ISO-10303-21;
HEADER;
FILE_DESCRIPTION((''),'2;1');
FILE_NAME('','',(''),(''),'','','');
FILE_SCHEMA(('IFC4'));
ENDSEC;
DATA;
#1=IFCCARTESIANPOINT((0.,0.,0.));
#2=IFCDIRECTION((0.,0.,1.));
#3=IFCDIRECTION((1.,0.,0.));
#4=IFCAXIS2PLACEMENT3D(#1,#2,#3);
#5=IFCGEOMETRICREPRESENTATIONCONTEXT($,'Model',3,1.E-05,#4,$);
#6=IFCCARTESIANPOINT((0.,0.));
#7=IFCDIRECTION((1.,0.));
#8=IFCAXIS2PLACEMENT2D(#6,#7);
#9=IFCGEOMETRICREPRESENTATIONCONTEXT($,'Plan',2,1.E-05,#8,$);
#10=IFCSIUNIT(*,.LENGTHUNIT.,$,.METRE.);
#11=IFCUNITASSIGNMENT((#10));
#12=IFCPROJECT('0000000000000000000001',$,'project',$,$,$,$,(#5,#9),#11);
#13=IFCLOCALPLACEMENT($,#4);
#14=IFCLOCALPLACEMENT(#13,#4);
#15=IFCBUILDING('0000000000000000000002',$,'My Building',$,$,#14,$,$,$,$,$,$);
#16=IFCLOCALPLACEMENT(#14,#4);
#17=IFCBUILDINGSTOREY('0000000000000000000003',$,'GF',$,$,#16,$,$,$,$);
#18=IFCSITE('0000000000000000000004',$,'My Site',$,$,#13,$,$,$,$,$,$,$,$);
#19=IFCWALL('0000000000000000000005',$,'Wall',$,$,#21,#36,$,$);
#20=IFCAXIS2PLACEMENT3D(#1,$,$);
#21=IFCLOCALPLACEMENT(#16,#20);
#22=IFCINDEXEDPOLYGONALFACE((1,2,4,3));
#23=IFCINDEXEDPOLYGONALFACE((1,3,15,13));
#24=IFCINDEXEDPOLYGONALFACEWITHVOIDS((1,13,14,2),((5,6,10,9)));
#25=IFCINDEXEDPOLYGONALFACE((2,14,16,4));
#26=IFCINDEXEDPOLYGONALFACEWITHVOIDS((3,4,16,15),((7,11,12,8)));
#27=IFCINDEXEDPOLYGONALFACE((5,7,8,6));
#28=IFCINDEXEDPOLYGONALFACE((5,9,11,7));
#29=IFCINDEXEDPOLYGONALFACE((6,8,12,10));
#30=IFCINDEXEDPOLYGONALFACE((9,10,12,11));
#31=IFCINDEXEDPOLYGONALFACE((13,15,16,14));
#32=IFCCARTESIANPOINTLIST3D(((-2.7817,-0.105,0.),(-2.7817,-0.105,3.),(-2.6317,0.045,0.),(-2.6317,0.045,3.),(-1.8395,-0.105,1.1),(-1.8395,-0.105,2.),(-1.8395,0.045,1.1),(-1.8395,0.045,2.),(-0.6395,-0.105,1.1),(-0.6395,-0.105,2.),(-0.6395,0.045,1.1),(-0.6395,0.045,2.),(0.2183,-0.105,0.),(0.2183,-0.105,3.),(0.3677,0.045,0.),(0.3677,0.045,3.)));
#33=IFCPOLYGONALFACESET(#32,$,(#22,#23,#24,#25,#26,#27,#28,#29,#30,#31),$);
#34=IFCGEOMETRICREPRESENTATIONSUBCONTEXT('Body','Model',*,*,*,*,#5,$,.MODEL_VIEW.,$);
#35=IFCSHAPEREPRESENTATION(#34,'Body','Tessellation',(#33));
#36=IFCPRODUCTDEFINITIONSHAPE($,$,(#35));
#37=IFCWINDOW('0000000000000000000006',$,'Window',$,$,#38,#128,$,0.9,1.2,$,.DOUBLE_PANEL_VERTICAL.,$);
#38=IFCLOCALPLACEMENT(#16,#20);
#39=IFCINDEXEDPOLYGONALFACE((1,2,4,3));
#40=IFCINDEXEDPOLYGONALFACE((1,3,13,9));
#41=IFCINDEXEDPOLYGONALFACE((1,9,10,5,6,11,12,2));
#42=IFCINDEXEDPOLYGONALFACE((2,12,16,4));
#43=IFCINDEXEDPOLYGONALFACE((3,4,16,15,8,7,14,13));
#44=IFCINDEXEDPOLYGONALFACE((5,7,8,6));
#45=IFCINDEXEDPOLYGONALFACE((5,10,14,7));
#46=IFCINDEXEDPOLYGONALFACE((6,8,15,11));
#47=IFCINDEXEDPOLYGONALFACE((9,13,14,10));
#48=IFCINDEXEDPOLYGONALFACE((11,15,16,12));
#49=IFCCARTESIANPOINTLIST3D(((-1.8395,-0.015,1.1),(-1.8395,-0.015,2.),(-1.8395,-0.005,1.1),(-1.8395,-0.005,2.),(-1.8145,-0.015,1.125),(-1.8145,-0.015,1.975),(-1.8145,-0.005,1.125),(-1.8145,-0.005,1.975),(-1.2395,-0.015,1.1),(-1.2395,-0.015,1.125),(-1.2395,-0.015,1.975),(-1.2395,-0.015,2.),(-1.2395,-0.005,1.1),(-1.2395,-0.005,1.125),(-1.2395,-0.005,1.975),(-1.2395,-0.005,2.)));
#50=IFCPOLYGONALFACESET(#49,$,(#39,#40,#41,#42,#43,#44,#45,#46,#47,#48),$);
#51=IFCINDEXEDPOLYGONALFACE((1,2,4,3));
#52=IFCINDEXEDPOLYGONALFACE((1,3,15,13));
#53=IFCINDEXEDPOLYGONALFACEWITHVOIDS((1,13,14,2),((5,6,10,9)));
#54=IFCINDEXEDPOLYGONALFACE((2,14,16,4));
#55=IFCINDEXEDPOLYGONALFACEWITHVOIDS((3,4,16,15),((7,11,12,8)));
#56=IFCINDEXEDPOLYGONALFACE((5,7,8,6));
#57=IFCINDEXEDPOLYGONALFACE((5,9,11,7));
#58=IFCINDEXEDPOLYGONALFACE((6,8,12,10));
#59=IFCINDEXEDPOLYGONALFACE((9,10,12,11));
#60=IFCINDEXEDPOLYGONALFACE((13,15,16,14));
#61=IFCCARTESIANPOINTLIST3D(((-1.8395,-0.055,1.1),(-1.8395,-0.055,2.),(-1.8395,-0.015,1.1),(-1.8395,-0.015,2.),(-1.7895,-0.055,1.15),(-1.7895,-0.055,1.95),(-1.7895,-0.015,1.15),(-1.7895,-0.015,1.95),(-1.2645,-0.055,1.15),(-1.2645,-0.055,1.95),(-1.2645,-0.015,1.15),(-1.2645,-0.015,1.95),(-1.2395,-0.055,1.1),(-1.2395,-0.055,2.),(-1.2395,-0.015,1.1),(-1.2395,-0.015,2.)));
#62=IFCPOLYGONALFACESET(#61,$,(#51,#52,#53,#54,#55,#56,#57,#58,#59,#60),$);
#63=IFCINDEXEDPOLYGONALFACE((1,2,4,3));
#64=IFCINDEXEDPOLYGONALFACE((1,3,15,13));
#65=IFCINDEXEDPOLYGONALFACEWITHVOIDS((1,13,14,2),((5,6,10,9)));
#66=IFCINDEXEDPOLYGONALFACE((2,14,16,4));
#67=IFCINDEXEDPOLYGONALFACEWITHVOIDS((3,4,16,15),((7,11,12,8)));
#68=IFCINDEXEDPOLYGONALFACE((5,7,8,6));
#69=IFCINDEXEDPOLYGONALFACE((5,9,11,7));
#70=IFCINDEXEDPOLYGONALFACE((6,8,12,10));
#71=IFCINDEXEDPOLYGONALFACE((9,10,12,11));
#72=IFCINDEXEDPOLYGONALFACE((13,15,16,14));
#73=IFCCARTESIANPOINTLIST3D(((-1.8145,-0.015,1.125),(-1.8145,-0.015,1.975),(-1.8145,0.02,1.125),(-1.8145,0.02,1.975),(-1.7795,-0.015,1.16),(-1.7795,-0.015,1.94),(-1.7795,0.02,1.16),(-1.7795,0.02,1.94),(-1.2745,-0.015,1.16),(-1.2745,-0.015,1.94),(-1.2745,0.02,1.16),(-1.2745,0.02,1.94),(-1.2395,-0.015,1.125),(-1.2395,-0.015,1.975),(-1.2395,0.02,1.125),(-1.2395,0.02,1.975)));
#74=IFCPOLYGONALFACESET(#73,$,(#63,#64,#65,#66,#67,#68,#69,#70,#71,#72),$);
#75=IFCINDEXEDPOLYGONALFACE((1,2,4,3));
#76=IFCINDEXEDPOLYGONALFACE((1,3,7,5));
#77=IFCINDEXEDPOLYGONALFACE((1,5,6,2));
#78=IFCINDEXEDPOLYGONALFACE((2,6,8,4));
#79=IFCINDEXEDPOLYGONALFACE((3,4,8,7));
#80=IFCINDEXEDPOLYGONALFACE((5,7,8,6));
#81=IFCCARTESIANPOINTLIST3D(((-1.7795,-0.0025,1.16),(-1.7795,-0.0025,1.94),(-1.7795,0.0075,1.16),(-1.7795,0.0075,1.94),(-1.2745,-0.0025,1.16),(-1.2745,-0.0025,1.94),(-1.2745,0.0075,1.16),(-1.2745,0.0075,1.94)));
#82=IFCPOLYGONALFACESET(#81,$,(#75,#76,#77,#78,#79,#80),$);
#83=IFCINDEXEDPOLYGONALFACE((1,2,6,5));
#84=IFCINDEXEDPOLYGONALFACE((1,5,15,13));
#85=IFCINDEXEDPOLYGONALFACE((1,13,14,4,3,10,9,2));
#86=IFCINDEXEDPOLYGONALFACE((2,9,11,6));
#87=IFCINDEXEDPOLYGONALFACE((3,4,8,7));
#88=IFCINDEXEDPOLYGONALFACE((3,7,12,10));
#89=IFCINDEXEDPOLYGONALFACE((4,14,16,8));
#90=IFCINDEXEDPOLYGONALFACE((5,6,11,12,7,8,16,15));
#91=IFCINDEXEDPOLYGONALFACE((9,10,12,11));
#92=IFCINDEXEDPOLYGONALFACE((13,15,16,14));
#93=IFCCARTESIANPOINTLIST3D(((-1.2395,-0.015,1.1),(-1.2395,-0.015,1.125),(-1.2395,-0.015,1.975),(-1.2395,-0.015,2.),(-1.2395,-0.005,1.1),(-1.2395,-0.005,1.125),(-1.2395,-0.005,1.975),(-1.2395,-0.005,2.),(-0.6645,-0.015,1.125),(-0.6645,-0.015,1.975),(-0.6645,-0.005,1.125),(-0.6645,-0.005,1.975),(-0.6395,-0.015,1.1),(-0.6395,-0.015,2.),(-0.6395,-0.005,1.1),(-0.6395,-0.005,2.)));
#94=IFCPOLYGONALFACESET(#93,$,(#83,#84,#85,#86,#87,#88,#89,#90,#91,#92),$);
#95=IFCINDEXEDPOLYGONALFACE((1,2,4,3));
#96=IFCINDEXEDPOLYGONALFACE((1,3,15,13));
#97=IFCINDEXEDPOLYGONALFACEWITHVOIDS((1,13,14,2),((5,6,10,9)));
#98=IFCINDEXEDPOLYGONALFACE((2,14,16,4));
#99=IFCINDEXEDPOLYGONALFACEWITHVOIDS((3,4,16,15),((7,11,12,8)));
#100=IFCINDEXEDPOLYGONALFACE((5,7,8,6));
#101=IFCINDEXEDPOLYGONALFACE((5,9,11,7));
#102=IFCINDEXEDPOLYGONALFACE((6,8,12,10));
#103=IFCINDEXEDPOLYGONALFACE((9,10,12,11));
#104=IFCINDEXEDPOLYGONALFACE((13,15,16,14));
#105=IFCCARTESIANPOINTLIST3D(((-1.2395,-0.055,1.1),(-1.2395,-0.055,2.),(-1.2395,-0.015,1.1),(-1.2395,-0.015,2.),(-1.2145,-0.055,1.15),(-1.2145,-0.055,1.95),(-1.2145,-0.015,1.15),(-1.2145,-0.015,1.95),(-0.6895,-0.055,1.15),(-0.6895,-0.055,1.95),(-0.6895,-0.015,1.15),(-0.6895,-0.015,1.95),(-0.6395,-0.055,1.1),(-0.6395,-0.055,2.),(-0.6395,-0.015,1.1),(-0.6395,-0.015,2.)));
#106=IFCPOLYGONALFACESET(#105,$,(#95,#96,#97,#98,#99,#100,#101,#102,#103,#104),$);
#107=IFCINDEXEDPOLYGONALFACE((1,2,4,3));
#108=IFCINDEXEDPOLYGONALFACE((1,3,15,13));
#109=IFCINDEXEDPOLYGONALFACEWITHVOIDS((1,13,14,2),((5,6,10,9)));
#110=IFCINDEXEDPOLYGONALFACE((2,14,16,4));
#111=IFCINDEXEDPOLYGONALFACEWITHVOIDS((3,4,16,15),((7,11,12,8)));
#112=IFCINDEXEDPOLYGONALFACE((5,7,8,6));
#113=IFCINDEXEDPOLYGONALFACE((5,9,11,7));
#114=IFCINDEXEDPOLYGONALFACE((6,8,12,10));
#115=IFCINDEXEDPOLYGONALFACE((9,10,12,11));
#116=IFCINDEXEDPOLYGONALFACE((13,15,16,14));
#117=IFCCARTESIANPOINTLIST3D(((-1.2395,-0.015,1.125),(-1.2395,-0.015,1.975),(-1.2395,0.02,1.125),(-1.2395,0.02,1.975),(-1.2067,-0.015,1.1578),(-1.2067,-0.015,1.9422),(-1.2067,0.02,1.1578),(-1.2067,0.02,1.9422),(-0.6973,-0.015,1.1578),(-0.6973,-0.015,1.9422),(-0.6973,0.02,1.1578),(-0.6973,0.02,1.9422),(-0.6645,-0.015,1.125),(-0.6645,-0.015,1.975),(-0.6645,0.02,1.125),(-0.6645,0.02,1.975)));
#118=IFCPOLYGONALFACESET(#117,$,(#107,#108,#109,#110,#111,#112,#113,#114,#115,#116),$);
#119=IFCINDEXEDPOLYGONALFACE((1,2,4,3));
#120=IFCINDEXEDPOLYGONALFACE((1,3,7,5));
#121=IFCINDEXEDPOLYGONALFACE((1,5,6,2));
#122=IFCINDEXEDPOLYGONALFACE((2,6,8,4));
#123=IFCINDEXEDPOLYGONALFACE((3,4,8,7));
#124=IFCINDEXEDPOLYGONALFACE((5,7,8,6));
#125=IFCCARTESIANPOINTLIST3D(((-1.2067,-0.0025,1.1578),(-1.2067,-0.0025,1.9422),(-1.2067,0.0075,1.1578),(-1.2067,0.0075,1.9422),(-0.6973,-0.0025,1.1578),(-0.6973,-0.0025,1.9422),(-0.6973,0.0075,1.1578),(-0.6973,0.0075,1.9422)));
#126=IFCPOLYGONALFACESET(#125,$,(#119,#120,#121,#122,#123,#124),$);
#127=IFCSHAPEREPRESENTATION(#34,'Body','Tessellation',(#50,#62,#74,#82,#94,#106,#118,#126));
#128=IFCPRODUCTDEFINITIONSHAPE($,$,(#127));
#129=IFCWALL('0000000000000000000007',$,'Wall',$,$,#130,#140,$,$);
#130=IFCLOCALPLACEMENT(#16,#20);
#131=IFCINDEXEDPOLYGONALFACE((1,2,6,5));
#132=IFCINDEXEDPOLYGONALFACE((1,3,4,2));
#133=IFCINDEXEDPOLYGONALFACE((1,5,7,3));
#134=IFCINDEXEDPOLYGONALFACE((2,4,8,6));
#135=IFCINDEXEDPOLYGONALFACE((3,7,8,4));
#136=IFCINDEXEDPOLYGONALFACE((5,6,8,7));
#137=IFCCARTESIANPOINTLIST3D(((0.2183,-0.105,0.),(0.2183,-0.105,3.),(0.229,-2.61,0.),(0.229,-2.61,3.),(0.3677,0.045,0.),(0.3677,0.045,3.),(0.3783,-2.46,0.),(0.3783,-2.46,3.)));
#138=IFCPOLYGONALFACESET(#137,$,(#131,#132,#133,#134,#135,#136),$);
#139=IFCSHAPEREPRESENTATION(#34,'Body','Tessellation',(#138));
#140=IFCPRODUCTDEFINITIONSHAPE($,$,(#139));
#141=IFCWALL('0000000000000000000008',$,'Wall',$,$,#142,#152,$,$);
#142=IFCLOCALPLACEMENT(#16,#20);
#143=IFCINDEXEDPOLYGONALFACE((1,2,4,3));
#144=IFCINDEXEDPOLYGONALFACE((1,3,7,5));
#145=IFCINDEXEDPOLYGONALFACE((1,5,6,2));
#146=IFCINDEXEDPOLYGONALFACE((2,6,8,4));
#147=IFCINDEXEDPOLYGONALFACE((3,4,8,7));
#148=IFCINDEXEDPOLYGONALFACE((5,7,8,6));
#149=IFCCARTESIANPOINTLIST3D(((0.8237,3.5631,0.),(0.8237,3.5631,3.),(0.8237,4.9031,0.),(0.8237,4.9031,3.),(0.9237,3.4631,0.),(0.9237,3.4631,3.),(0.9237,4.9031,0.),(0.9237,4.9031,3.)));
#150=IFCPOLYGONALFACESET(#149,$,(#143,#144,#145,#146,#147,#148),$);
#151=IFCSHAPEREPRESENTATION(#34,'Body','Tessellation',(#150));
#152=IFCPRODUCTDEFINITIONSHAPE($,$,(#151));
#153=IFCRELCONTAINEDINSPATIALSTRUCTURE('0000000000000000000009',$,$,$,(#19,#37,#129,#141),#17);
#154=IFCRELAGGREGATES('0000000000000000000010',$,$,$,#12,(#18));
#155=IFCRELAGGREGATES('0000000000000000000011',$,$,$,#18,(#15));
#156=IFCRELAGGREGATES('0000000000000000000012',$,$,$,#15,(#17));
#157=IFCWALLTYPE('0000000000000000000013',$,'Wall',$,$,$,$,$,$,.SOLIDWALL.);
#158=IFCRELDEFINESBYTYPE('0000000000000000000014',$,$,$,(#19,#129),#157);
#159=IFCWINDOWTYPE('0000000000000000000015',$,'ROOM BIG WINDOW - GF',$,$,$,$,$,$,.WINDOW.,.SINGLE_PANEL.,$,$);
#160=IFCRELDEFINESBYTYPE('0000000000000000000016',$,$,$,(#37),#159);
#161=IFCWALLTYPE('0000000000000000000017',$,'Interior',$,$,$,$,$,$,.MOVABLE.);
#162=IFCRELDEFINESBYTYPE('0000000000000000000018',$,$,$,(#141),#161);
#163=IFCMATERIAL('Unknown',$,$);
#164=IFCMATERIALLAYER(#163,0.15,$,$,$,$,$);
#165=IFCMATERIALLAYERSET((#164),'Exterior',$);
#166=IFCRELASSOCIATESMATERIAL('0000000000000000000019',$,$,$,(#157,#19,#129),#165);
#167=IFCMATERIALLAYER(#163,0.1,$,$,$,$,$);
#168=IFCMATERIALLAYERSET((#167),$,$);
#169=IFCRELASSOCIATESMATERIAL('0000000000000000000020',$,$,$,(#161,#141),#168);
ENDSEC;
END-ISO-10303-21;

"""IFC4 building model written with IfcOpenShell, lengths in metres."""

from ifc_helpers import new_model, entity, si_unit, frame, origin_with_axes, origin_2d_with_axis, place, context, subcontext, project, spatial, line, indexed_curve, outline, extrude, shape, source, transform, mapped, material, layer, layer_set, layer_usage, type_object, type_shapes, element, fill, save


model = new_model("IFC4")

# Units and contexts
model_context = context("Model", 3, precision=1e-05, world=origin_with_axes())
plan_context = context("Plan", 2, precision=1e-05, world=origin_2d_with_axis())
body_context_1 = subcontext(model_context, "Body", "Model", "MODEL_VIEW")
body_context_2 = subcontext(plan_context, "Body", "Plan", "PLAN_VIEW")
ifc_project = project(units=[si_unit("LENGTHUNIT", "METRE")], contexts=[model_context, plan_context])

# Site, building, storey
site_placement = place(None, origin_with_axes())
site = spatial("IfcSite", under=ifc_project, at=site_placement, Name="My Site")
building_placement = place(site_placement, origin_with_axes())
building = spatial("IfcBuilding", under=site, at=building_placement, Name="My Building")
storey_placement = place(building_placement, origin_with_axes())
storey = spatial("IfcBuildingStorey", under=building, at=storey_placement, Name="GF")

# Shared definitions
ifc_material = material(Name="Unknown")
ifc_layer_1 = layer(ifc_material, 0.15)
ifc_layer_set_1 = layer_set([ifc_layer_1], Name="Exterior")
wall_type_1 = type_object("IfcWallType", Name="Wall", PredefinedType="SOLIDWALL", material=ifc_layer_set_1)

# Wall, opening, window
shared_shape_1 = source(origin_with_axes(), body_context_1, "Body", "SweptSolid", [
    extrude(outline(indexed_curve([(0.0, 0.0), (1.2, 0.0), (1.2, 0.9), (0.0, 0.9)], segments=[line(1, 2, 3, 4, 1)])), frame((0.0, -0.6, 0.0), z_axis=(0.0, -1.0, 0.0), x_axis=(1.0, 0.0, 0.0)), (0.0, 0.0, -1.0), 1.2),
])
window_type_1 = type_object("IfcWindowType", Name="ROOM BIG WINDOW - GF", PartitioningType="SINGLE_PANEL", PredefinedType="WINDOW")
shared_shape_2 = source(origin_with_axes(), body_context_1, "Body", "SweptSolid", [
    extrude(outline(indexed_curve([(0.6, 0.0), (0.0, 0.0), (0.0, 0.9), (0.6, 0.9), (0.6, 0.875), (0.025, 0.875), (0.025, 0.025), (0.6, 0.025)], segments=[line(1, 2, 3, 4, 5, 6, 7, 8, 1)])), frame((0.0, 0.09, 0.0), z_axis=(0.0, -1.0, 0.0), x_axis=(1.0, 0.0, 0.0)), (0.0, 0.0, -1.0), 0.01),
    extrude(outline(indexed_curve([(0.0, 0.0), (0.6, 0.0), (0.6, 0.9), (0.0, 0.9)], segments=[line(1, 2, 3, 4, 1)]), holes=[indexed_curve([(0.05, 0.05), (0.575, 0.05), (0.575, 0.85), (0.05, 0.85)], segments=[line(1, 2, 3, 4, 1)])]), frame((0.0, 0.05, 0.0), z_axis=(0.0, -1.0, 0.0), x_axis=(1.0, 0.0, 0.0)), (0.0, 0.0, -1.0), 0.04),
    extrude(outline(indexed_curve([(0.0, 0.0), (0.575, 0.0), (0.575, 0.85), (0.0, 0.85)], segments=[line(1, 2, 3, 4, 1)]), holes=[indexed_curve([(0.035, 0.035), (0.54, 0.035), (0.54, 0.815), (0.035, 0.815)], segments=[line(1, 2, 3, 4, 1)])]), frame((0.025, 0.09, 0.025), z_axis=(0.0, -1.0, 0.0), x_axis=(1.0, 0.0, 0.0)), (0.0, 0.0, -1.0), 0.035),
    extrude(outline(indexed_curve([(0.035, 0.035), (0.54, 0.035), (0.54, 0.815), (0.035, 0.815)], segments=[line(1, 2, 3, 4, 1)])), frame((0.025, 0.1025, 0.025), z_axis=(0.0, -1.0, 0.0), x_axis=(1.0, 0.0, 0.0)), (0.0, 0.0, -1.0), 0.01),
    extrude(outline(indexed_curve([(0.0, 0.9), (0.6, 0.9), (0.6, 0.0), (0.0, 0.0), (0.0, 0.025), (0.575, 0.025), (0.575, 0.875), (0.0, 0.875)], segments=[line(1, 2, 3, 4, 5, 6, 7, 8, 1)])), frame((0.6, 0.09, 0.0), z_axis=(0.0, -1.0, 0.0), x_axis=(1.0, 0.0, 0.0)), (0.0, 0.0, -1.0), 0.01),
    extrude(outline(indexed_curve([(0.0, 0.0), (0.6, 0.0), (0.6, 0.9), (0.0, 0.9)], segments=[line(1, 2, 3, 4, 1)]), holes=[indexed_curve([(0.025, 0.05), (0.55, 0.05), (0.55, 0.85), (0.025, 0.85)], segments=[line(1, 2, 3, 4, 1)])]), frame((0.6, 0.05, 0.0), z_axis=(0.0, -1.0, 0.0), x_axis=(1.0, 0.0, 0.0)), (0.0, 0.0, -1.0), 0.04),
    extrude(outline(indexed_curve([(0.0, 0.0), (0.575, 0.0), (0.575, 0.85), (0.0, 0.85)], segments=[line(1, 2, 3, 4, 1)]), holes=[indexed_curve([(0.0328, 0.0328), (0.5422, 0.0328), (0.5422, 0.8172), (0.0328, 0.8172)], segments=[line(1, 2, 3, 4, 1)])]), frame((0.6, 0.09, 0.025), z_axis=(0.0, -1.0, 0.0), x_axis=(1.0, 0.0, 0.0)), (0.0, 0.0, -1.0), 0.035),
    extrude(outline(indexed_curve([(0.0328, 0.0328), (0.5422, 0.0328), (0.5422, 0.8172), (0.0328, 0.8172)], segments=[line(1, 2, 3, 4, 1)])), frame((0.6, 0.1025, 0.025), z_axis=(0.0, -1.0, 0.0), x_axis=(1.0, 0.0, 0.0)), (0.0, 0.0, -1.0), 0.01),
])
shared_shape_3 = source(origin_with_axes(), body_context_2, "Body", "Curve2D", [
    entity("IfcIndexedPolyCurve", entity("IfcCartesianPointList2D", [[0.05, 0.05], [0.575, 0.05]])),
    entity("IfcIndexedPolyCurve", entity("IfcCartesianPointList2D", [[0.0, 0.1], [0.025, 0.1], [0.025, 0.09], [0.05, 0.09], [0.05, 0.05], [0.0, 0.05]]), [entity("IfcLineIndex", [1, 2, 3, 4, 5, 6, 1])]),
    entity("IfcIndexedPolyCurve", entity("IfcCartesianPointList2D", [[0.6, 0.1], [0.6, 0.1], [0.6, 0.09], [0.575, 0.09], [0.575, 0.05], [0.6, 0.05]])),
    entity("IfcIndexedPolyCurve", entity("IfcCartesianPointList2D", [[0.025, 0.09], [0.06, 0.09], [0.06, 0.125], [0.025, 0.125]]), [entity("IfcLineIndex", [1, 2, 3, 4, 1])]),
    entity("IfcIndexedPolyCurve", entity("IfcCartesianPointList2D", [[0.6, 0.09], [0.565, 0.09], [0.565, 0.125], [0.6, 0.125]]), [entity("IfcLineIndex", [1, 2, 3, 4, 1])]),
    entity("IfcIndexedPolyCurve", entity("IfcCartesianPointList2D", [[0.06, 0.09], [0.565, 0.09]])),
    entity("IfcIndexedPolyCurve", entity("IfcCartesianPointList2D", [[0.06, 0.125], [0.565, 0.125]])),
    entity("IfcIndexedPolyCurve", entity("IfcCartesianPointList2D", [[0.06, 0.1075], [0.565, 0.1075]])),
    entity("IfcIndexedPolyCurve", entity("IfcCartesianPointList2D", [[0.625, 0.05], [1.15, 0.05]])),
    entity("IfcIndexedPolyCurve", entity("IfcCartesianPointList2D", [[0.6, 0.1], [0.6, 0.1], [0.6, 0.09], [0.625, 0.09], [0.625, 0.05], [0.6, 0.05]])),
    entity("IfcIndexedPolyCurve", entity("IfcCartesianPointList2D", [[1.2, 0.1], [1.175, 0.1], [1.175, 0.09], [1.15, 0.09], [1.15, 0.05], [1.2, 0.05]]), [entity("IfcLineIndex", [1, 2, 3, 4, 5, 6, 1])]),
    entity("IfcIndexedPolyCurve", entity("IfcCartesianPointList2D", [[0.6, 0.09], [0.6328, 0.09], [0.6328, 0.125], [0.6, 0.125]]), [entity("IfcLineIndex", [1, 2, 3, 4, 1])]),
    entity("IfcIndexedPolyCurve", entity("IfcCartesianPointList2D", [[1.175, 0.09], [1.1422, 0.09], [1.1422, 0.125], [1.175, 0.125]]), [entity("IfcLineIndex", [1, 2, 3, 4, 1])]),
    entity("IfcIndexedPolyCurve", entity("IfcCartesianPointList2D", [[0.6328, 0.09], [1.1422, 0.09]])),
    entity("IfcIndexedPolyCurve", entity("IfcCartesianPointList2D", [[0.6328, 0.125], [1.1422, 0.125]])),
    entity("IfcIndexedPolyCurve", entity("IfcCartesianPointList2D", [[0.6328, 0.1075], [1.1422, 0.1075]])),
])
type_shapes(window_type_1, [shared_shape_2, shared_shape_3])
ifc_layer_usage_1 = layer_usage(ifc_layer_set_1, "AXIS2", "POSITIVE", 0.0)
wall_1_placement = place(storey_placement, frame((-2.7817, -0.105, 0.0), z_axis=(0.0, 0.0, 1.0), x_axis=(1.0, 0.0, 0.0)))
wall_1 = element("IfcWall", 1, at=wall_1_placement, inside=storey, type_object=wall_type_1, material=ifc_layer_usage_1, Name="Wall", context=body_context_1, shape_type="SweptSolid", body=[
    extrude(outline(indexed_curve([(0.0, 0.0), (0.15, 0.15), (3.1494, 0.15), (3.0, 0.0)], segments=[line(1, 2, 3, 4, 1)])), origin_with_axes(), (0.0, 0.0, 1.0), 3.0),
])
opening_1_placement = place(wall_1_placement, frame((0.9421, 0.0, 1.1), z_axis=(0.0, 0.0, 1.0), x_axis=(1.0, 0.0, 0.0)))
opening_1 = element("IfcOpeningElement", 2, at=opening_1_placement, cuts=wall_1, PredefinedType="OPENING", context=body_context_1, shape_type="MappedRepresentation", body=[
    mapped(shared_shape_1, transform((0.0, 0.0, 0.0), x_axis=(1.0, 0.0, 0.0), y_axis=(0.0, 1.0, 0.0), z_axis=(0.0, 0.0, 1.0), scale=1.0)),
])
window_1_placement = place(opening_1_placement, frame((0.0, 0.0, 0.0), z_axis=(0.0, 0.0, 1.0), x_axis=(1.0, 0.0, 0.0)))
window_1 = element("IfcWindow", 3, at=window_1_placement, inside=storey, type_object=window_type_1, Name="Window", OverallHeight=0.9, OverallWidth=1.2, PartitioningType="DOUBLE_PANEL_VERTICAL", shapes=[
    shape(body_context_1, "Body", "MappedRepresentation", [mapped(shared_shape_2, transform((0.0, 0.0, 0.0), x_axis=(1.0, 0.0, 0.0), y_axis=(0.0, 1.0, 0.0), z_axis=(0.0, 0.0, 1.0), scale=1.0))]),
    shape(body_context_2, "Body", "MappedRepresentation", [mapped(shared_shape_3, transform((0.0, 0.0, 0.0), x_axis=(1.0, 0.0, 0.0), y_axis=(0.0, 1.0, 0.0), z_axis=(0.0, 0.0, 1.0), scale=1.0))]),
])
fill(opening_1, window_1)

# Walls
ifc_layer_usage_2 = layer_usage(ifc_layer_set_1, "AXIS2", "POSITIVE", 0.0)
wall_2_placement = place(storey_placement, frame((0.2183, -0.105, 0.0), z_axis=(0.0, 0.0, 1.0), x_axis=(0.004245, -0.999991, 0.0)))
element("IfcWall", 4, at=wall_2_placement, inside=storey, type_object=wall_type_1, material=ifc_layer_usage_2, Name="Wall", context=body_context_1, shape_type="SweptSolid", body=[
    extrude(outline(indexed_curve([(0.0, 0.0), (-0.1494, 0.15), (2.3557, 0.15), (2.505, 0.0)], segments=[line(1, 2, 3, 4, 1)])), origin_with_axes(), (0.0, 0.0, 1.0), 3.0),
])
ifc_layer_2 = layer(ifc_material, 0.1)
ifc_layer_set_2 = layer_set([ifc_layer_2])
ifc_layer_usage_3 = layer_usage(ifc_layer_set_2, "AXIS2", "POSITIVE", 0.0)
wall_type_2 = type_object("IfcWallType", Name="Interior", PredefinedType="MOVABLE", material=ifc_layer_set_2)
wall_3_placement = place(storey_placement, frame((0.8237, 4.9031, 0.0), z_axis=(0.0, 0.0, 1.0), x_axis=(0.0, -1.0, 0.0)))
element("IfcWall", 5, at=wall_3_placement, inside=storey, type_object=wall_type_2, material=ifc_layer_usage_3, Name="Wall", context=body_context_1, shape_type="SweptSolid", body=[
    extrude(outline(indexed_curve([(0.0, 0.0), (0.0, 0.1), (1.44, 0.1), (1.34, 0.0)], segments=[line(1, 2, 3, 4, 1)])), origin_with_axes(), (0.0, 0.0, 1.0), 3.0),
])

save(model, "model.ifc")
